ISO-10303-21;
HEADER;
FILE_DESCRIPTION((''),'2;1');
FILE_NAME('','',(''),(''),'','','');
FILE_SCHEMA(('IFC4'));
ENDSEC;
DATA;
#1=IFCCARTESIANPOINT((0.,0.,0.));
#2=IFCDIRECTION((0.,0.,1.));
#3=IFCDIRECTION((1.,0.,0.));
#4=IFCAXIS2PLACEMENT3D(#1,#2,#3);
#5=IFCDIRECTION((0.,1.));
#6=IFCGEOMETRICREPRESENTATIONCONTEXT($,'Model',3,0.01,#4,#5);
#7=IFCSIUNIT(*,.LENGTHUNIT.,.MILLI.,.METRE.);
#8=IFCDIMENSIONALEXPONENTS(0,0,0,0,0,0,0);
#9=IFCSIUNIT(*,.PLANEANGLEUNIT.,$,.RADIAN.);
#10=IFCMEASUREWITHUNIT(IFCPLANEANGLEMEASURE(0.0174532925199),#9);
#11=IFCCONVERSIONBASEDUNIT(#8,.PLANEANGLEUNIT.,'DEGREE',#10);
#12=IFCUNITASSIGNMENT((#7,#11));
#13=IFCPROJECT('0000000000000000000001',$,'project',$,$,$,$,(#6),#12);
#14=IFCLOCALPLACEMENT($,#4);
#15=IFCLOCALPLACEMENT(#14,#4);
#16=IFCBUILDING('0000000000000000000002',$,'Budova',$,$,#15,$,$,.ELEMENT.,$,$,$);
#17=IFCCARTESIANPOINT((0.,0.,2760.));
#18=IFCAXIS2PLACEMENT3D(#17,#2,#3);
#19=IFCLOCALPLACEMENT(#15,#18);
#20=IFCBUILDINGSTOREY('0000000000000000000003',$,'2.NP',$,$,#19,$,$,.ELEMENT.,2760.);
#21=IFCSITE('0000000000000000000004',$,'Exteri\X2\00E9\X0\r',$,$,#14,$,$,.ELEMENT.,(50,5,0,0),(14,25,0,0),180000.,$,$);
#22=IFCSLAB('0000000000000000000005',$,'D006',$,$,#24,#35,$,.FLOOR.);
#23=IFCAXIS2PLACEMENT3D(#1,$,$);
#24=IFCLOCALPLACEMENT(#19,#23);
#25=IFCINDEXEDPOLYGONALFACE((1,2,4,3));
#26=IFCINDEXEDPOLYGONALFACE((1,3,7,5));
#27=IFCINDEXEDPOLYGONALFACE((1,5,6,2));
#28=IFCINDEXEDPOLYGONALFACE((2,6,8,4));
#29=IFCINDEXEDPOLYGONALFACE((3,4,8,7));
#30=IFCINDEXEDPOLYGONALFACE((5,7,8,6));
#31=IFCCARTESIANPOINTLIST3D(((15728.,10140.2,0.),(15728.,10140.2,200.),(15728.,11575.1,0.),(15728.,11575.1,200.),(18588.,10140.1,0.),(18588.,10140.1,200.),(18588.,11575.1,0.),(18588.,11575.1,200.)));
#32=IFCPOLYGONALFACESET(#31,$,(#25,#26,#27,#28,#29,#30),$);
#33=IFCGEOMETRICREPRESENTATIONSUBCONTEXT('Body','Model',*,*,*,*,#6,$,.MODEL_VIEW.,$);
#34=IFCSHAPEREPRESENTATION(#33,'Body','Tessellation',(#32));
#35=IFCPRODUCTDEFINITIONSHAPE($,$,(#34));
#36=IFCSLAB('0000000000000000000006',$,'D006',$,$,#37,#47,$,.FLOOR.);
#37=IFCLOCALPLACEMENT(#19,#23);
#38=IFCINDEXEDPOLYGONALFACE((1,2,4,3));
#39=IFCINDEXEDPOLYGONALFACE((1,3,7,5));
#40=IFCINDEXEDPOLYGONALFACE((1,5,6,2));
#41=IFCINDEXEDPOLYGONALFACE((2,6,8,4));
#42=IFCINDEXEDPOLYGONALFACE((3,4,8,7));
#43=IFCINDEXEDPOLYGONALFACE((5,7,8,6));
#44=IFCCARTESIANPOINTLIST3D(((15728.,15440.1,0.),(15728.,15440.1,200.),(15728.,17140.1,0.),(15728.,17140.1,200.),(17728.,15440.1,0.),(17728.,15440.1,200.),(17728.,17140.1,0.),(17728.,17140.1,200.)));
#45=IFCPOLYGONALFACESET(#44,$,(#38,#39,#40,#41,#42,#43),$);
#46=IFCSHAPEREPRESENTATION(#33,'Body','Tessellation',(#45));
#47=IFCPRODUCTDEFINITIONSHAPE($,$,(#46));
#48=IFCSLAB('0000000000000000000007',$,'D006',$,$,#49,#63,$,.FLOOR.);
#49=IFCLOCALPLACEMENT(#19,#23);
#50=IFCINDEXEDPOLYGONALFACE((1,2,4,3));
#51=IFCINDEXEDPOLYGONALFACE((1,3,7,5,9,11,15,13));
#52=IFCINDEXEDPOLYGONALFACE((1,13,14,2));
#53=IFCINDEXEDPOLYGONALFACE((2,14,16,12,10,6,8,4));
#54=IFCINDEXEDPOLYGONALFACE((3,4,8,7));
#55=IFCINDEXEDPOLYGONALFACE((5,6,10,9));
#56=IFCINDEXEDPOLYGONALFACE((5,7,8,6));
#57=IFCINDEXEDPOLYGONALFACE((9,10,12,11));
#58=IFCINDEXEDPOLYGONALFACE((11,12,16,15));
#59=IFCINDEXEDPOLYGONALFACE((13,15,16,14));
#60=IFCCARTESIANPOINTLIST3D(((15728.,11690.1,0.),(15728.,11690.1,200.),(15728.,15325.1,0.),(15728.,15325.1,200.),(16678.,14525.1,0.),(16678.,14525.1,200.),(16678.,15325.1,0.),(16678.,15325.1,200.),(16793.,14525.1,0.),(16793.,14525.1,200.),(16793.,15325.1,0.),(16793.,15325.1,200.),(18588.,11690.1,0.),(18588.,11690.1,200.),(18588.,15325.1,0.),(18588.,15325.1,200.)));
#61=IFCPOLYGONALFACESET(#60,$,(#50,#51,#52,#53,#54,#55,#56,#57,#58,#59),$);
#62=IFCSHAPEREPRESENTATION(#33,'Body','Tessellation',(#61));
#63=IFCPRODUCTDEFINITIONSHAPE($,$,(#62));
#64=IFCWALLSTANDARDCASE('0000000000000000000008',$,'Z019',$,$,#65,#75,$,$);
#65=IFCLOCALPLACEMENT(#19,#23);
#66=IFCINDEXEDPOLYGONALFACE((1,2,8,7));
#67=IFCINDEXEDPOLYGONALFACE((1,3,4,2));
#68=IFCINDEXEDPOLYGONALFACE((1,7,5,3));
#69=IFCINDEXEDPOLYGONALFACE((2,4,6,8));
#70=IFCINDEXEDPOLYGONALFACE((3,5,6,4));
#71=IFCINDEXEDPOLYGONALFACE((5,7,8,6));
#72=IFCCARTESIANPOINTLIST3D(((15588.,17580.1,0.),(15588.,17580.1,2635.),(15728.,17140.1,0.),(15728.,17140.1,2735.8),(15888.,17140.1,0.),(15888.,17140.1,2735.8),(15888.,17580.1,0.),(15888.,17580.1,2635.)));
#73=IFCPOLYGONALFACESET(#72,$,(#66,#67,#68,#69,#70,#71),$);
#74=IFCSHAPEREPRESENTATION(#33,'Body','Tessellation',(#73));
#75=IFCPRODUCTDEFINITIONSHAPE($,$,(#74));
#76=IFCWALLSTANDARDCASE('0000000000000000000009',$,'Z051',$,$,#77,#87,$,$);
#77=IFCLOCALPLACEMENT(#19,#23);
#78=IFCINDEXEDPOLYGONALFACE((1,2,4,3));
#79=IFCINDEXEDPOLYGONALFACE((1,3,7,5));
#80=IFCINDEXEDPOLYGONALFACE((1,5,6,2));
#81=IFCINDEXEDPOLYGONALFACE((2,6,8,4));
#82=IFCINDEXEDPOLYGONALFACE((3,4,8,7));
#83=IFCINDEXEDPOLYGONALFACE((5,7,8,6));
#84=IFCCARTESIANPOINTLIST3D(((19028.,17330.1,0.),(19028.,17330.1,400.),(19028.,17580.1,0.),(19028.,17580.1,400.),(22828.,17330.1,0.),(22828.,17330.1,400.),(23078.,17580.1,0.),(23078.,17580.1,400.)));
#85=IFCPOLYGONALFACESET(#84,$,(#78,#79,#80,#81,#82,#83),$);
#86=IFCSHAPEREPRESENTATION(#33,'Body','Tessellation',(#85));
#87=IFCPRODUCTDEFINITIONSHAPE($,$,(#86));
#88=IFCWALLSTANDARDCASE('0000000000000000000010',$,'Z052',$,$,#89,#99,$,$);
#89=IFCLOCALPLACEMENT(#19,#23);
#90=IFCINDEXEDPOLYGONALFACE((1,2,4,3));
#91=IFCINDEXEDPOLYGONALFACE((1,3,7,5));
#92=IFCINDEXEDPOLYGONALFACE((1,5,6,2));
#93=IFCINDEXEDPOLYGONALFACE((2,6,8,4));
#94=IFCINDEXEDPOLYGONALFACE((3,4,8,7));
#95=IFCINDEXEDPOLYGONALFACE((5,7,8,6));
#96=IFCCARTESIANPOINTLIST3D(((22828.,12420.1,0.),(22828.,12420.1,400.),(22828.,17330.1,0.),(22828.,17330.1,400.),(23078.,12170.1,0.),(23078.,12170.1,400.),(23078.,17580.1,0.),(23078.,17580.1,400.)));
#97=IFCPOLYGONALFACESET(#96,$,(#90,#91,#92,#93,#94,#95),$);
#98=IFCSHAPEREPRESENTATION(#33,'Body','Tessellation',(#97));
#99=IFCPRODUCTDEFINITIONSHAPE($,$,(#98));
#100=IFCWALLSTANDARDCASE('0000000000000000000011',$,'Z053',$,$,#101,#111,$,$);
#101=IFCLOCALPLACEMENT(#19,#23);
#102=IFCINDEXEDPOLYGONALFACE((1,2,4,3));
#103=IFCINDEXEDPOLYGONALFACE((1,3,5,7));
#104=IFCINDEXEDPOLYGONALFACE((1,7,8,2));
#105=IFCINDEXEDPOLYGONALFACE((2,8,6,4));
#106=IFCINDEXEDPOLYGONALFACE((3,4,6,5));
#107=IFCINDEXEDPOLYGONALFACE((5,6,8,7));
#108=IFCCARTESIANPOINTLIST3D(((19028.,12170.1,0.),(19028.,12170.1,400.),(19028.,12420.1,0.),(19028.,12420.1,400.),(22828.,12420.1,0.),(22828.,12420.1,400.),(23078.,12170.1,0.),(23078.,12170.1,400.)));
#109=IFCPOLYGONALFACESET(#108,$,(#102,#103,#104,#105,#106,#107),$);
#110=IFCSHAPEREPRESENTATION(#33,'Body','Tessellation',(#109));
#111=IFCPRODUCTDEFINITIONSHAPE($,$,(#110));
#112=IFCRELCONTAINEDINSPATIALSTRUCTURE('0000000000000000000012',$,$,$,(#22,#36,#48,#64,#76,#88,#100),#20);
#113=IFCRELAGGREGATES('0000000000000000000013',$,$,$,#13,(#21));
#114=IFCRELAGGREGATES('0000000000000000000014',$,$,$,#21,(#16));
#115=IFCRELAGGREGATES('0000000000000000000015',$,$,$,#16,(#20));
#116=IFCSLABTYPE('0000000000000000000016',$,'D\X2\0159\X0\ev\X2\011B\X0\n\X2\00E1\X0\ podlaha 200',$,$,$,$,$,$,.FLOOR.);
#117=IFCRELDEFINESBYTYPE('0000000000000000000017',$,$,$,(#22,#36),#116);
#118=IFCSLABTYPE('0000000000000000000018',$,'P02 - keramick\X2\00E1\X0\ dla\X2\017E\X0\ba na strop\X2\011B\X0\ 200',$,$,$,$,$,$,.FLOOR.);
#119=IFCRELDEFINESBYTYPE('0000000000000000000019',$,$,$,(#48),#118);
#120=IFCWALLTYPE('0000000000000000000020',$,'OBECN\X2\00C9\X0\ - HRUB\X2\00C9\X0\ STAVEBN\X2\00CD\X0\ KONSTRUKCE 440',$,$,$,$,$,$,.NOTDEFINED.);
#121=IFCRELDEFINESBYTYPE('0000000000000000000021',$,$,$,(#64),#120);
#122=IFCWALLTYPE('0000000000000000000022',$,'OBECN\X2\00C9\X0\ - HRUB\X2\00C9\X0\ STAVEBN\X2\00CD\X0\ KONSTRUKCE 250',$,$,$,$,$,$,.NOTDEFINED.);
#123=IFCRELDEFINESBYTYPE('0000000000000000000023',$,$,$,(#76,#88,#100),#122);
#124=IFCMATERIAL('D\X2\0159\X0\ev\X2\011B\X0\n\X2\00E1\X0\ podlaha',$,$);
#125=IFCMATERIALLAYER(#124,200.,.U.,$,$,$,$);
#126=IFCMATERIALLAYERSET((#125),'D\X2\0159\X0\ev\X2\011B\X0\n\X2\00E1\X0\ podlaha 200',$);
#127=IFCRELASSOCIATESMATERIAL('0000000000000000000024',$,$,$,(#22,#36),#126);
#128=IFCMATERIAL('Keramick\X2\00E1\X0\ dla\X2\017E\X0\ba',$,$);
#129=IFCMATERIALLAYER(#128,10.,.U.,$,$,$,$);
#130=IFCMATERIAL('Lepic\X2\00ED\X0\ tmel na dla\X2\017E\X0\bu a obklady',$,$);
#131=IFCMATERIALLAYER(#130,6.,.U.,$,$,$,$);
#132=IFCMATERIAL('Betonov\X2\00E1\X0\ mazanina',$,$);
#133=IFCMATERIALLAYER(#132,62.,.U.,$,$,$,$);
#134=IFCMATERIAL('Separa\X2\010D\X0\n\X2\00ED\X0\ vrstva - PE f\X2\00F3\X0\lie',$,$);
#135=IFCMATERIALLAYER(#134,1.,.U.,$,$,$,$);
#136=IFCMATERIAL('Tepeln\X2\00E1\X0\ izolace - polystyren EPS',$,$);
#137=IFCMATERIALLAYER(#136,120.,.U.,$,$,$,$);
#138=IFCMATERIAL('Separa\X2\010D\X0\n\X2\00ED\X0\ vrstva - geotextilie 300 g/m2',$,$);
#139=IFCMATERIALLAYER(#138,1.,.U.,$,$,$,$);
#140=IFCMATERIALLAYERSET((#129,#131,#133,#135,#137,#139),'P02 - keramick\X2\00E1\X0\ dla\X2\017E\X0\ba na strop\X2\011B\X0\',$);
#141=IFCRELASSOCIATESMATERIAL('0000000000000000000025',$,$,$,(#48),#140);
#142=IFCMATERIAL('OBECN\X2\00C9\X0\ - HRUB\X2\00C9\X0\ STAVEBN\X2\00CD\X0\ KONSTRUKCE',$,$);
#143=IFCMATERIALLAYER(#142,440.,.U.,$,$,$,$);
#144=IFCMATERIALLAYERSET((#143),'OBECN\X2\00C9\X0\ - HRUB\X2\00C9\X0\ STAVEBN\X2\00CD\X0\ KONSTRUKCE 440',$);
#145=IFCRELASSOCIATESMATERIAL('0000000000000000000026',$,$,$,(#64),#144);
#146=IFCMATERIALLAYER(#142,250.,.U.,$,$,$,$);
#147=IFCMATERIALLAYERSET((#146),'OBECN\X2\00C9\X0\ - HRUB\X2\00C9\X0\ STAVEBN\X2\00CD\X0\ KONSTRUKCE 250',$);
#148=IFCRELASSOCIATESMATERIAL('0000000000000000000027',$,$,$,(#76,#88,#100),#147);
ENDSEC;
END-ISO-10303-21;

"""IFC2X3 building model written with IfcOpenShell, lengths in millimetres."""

from ifc_helpers import new_model, entity, si_unit, converted_unit, direction, frame, origin_with_axes, place, context, subcontext, project, spatial, polyline, outline, extrude, clip, halfspace, material, layer, layer_set, layer_usage, type_object, element, save


model = new_model("IFC2X3")

# Units and contexts
model_context = context("Model", 3, precision=0.01, world=origin_with_axes(), true_north=direction((0.0, 1.0)))
body_context = subcontext(model_context, "Body", "Model", "MODEL_VIEW")
ifc_project = project(units=[si_unit("LENGTHUNIT", "METRE", prefix="MILLI"), converted_unit("PLANEANGLEUNIT", "DEGREE", entity("IfcPlaneAngleMeasure", 0.0174532925199), si_unit("PLANEANGLEUNIT", "RADIAN"), dimensions=[0, 0, 0, 0, 0, 0, 0])], contexts=[model_context])

# Site, building, storey
site_placement = place(None, origin_with_axes())
site = spatial("IfcSite", under=ifc_project, at=site_placement, Name="Exteriér", CompositionType="ELEMENT", RefLatitude=(50, 5, 0, 0), RefLongitude=(14, 25, 0, 0), RefElevation=180000.0)
building_placement = place(site_placement, origin_with_axes())
building = spatial("IfcBuilding", under=site, at=building_placement, Name="Budova", CompositionType="ELEMENT")
storey_placement = place(building_placement, frame((0.0, 0.0, 2760.0), z_axis=(0.0, 0.0, 1.0), x_axis=(1.0, 0.0, 0.0)))
storey = spatial("IfcBuildingStorey", under=building, at=storey_placement, Name="2.NP", CompositionType="ELEMENT", Elevation=2760.0)

# Slabs
ifc_material_1 = material(Name="Dřevěná podlaha")
ifc_layer_1 = layer(ifc_material_1, 200.0, ventilated="UNKNOWN")
ifc_layer_set_1 = layer_set([ifc_layer_1], Name="Dřevěná podlaha 200")
ifc_layer_usage_1 = layer_usage(ifc_layer_set_1, "AXIS3", "NEGATIVE", 200.0)
slab_type_1 = type_object("IfcSlabType", Name="Dřevěná podlaha 200", PredefinedType="FLOOR")
slab_1_placement = place(storey_placement, frame((15728.0, 11575.1, 0.0), z_axis=(0.0, 0.0, 1.0), x_axis=(1.0, 0.0, 0.0)))
element("IfcSlab", 1, at=slab_1_placement, inside=storey, type_object=slab_type_1, material=ifc_layer_usage_1, Name="D006", PredefinedType="FLOOR", context=body_context, shape_type="SweptSolid", body=[
    extrude(outline(polyline([(0.0, 0.0), (0.0, -1435.0), (2860.0, -1435.0), (2860.0, 0.0), (0.0, 0.0)])), origin_with_axes(), (0.0, 0.0, 1.0), 200.0),
])
ifc_layer_usage_2 = layer_usage(ifc_layer_set_1, "AXIS3", "NEGATIVE", 200.0)
slab_2_placement = place(storey_placement, frame((15728.0, 17140.1, 0.0), z_axis=(0.0, 0.0, 1.0), x_axis=(1.0, 0.0, 0.0)))
element("IfcSlab", 2, at=slab_2_placement, inside=storey, type_object=slab_type_1, material=ifc_layer_usage_2, Name="D006", PredefinedType="FLOOR", context=body_context, shape_type="SweptSolid", body=[
    extrude(outline(polyline([(0.0, 0.0), (0.0, -1700.0), (2000.0, -1700.0), (2000.0, 0.0), (0.0, 0.0)])), origin_with_axes(), (0.0, 0.0, 1.0), 200.0),
])
ifc_material_2 = material(Name="Keramická dlažba")
ifc_layer_2 = layer(ifc_material_2, 10.0, ventilated="UNKNOWN")
ifc_material_3 = material(Name="Lepicí tmel na dlažbu a obklady")
ifc_layer_3 = layer(ifc_material_3, 6.0, ventilated="UNKNOWN")
ifc_material_4 = material(Name="Betonová mazanina")
ifc_layer_4 = layer(ifc_material_4, 62.0, ventilated="UNKNOWN")
ifc_material_5 = material(Name="Separační vrstva - PE fólie")
ifc_layer_5 = layer(ifc_material_5, 1.0, ventilated="UNKNOWN")
ifc_material_6 = material(Name="Tepelná izolace - polystyren EPS")
ifc_layer_6 = layer(ifc_material_6, 120.0, ventilated="UNKNOWN")
ifc_material_7 = material(Name="Separační vrstva - geotextilie 300 g/m2")
ifc_layer_7 = layer(ifc_material_7, 1.0, ventilated="UNKNOWN")
ifc_layer_set_2 = layer_set([ifc_layer_2, ifc_layer_3, ifc_layer_4, ifc_layer_5, ifc_layer_6, ifc_layer_7], Name="P02 - keramická dlažba na stropě")
ifc_layer_usage_3 = layer_usage(ifc_layer_set_2, "AXIS3", "NEGATIVE", 200.0)
slab_type_2 = type_object("IfcSlabType", Name="P02 - keramická dlažba na stropě 200", PredefinedType="FLOOR")
slab_3_placement = place(storey_placement, frame((15728.0, 15325.1, 0.0), z_axis=(0.0, 0.0, 1.0), x_axis=(1.0, 0.0, 0.0)))
element("IfcSlab", 3, at=slab_3_placement, inside=storey, type_object=slab_type_2, material=ifc_layer_usage_3, Name="D006", PredefinedType="FLOOR", context=body_context, shape_type="SweptSolid", body=[
    extrude(outline(polyline([(0.0, 0.0), (0.0, -3635.0), (2860.0, -3635.0), (2860.0, 0.0), (1065.0, 0.0), (1065.0, -800.0), (950.0, -800.0), (950.0, 0.0), (0.0, 0.0)])), origin_with_axes(), (0.0, 0.0, 1.0), 200.0),
])

# Wall
ifc_material_8 = material(Name="OBECNÉ - HRUBÉ STAVEBNÍ KONSTRUKCE")
ifc_layer_8 = layer(ifc_material_8, 440.0, ventilated="UNKNOWN")
ifc_layer_set_3 = layer_set([ifc_layer_8], Name="OBECNÉ - HRUBÉ STAVEBNÍ KONSTRUKCE 440")
ifc_layer_usage_4 = layer_usage(ifc_layer_set_3, "AXIS2", "POSITIVE", -440.0)
wall_type_1 = type_object("IfcWallType", Name="OBECNÉ - HRUBÉ STAVEBNÍ KONSTRUKCE 440", PredefinedType="NOTDEFINED")
wall_1_placement = place(storey_placement, frame((15588.0, 17580.1, 0.0), z_axis=(0.0, 0.0, 1.0), x_axis=(1.0, 0.0, 0.0)))
element("IfcWallStandardCase", 4, at=wall_1_placement, inside=storey, type_object=wall_type_1, material=ifc_layer_usage_4, Name="Z019", context=body_context, shape_type="Clipping", body=[
    clip(extrude(outline(polyline([(140.0, -440.0), (300.0, -440.0), (300.0, 0.0), (0.0, 0.0), (140.0, -440.0)])), origin_with_axes(), (0.0, 0.0, 1.0), 3000.0), halfspace(frame((0.0, 573.4, 2503.7), z_axis=(0.0, -0.22325, -0.974761), x_axis=(0.0, 0.974761, -0.22325)), True)),
])

# Walls
ifc_layer_9 = layer(ifc_material_8, 250.0, ventilated="UNKNOWN")
ifc_layer_set_4 = layer_set([ifc_layer_9], Name="OBECNÉ - HRUBÉ STAVEBNÍ KONSTRUKCE 250")
ifc_layer_usage_5 = layer_usage(ifc_layer_set_4, "AXIS2", "POSITIVE", -250.0)
wall_type_2 = type_object("IfcWallType", Name="OBECNÉ - HRUBÉ STAVEBNÍ KONSTRUKCE 250", PredefinedType="NOTDEFINED")
wall_2_placement = place(storey_placement, frame((19028.0, 17580.1, 0.0), z_axis=(0.0, 0.0, 1.0), x_axis=(1.0, 0.0, 0.0)))
element("IfcWallStandardCase", 5, at=wall_2_placement, inside=storey, type_object=wall_type_2, material=ifc_layer_usage_5, Name="Z051", context=body_context, shape_type="SweptSolid", body=[
    extrude(outline(polyline([(0.0, -250.0), (3800.0, -250.0), (4050.0, 0.0), (0.0, 0.0), (0.0, -250.0)])), origin_with_axes(), (0.0, 0.0, 1.0), 400.0),
])
ifc_layer_usage_6 = layer_usage(ifc_layer_set_4, "AXIS2", "POSITIVE", -250.0)
wall_3_placement = place(storey_placement, frame((23078.0, 17580.1, 0.0), z_axis=(0.0, 0.0, 1.0), x_axis=(0.0, -1.0, 0.0)))
element("IfcWallStandardCase", 6, at=wall_3_placement, inside=storey, type_object=wall_type_2, material=ifc_layer_usage_6, Name="Z052", context=body_context, shape_type="SweptSolid", body=[
    extrude(outline(polyline([(250.0, -250.0), (5160.0, -250.0), (5410.0, 0.0), (0.0, 0.0), (250.0, -250.0)])), origin_with_axes(), (0.0, 0.0, 1.0), 400.0),
])
ifc_layer_usage_7 = layer_usage(ifc_layer_set_4, "AXIS2", "POSITIVE", -250.0)
wall_4_placement = place(storey_placement, frame((23078.0, 12170.1, 0.0), z_axis=(0.0, 0.0, 1.0), x_axis=(-1.0, 0.0, 0.0)))
element("IfcWallStandardCase", 7, at=wall_4_placement, inside=storey, type_object=wall_type_2, material=ifc_layer_usage_7, Name="Z053", context=body_context, shape_type="SweptSolid", body=[
    extrude(outline(polyline([(250.0, -250.0), (4050.0, -250.0), (4050.0, 0.0), (0.0, 0.0), (250.0, -250.0)])), origin_with_axes(), (0.0, 0.0, 1.0), 400.0),
])

save(model, "model.ifc")
